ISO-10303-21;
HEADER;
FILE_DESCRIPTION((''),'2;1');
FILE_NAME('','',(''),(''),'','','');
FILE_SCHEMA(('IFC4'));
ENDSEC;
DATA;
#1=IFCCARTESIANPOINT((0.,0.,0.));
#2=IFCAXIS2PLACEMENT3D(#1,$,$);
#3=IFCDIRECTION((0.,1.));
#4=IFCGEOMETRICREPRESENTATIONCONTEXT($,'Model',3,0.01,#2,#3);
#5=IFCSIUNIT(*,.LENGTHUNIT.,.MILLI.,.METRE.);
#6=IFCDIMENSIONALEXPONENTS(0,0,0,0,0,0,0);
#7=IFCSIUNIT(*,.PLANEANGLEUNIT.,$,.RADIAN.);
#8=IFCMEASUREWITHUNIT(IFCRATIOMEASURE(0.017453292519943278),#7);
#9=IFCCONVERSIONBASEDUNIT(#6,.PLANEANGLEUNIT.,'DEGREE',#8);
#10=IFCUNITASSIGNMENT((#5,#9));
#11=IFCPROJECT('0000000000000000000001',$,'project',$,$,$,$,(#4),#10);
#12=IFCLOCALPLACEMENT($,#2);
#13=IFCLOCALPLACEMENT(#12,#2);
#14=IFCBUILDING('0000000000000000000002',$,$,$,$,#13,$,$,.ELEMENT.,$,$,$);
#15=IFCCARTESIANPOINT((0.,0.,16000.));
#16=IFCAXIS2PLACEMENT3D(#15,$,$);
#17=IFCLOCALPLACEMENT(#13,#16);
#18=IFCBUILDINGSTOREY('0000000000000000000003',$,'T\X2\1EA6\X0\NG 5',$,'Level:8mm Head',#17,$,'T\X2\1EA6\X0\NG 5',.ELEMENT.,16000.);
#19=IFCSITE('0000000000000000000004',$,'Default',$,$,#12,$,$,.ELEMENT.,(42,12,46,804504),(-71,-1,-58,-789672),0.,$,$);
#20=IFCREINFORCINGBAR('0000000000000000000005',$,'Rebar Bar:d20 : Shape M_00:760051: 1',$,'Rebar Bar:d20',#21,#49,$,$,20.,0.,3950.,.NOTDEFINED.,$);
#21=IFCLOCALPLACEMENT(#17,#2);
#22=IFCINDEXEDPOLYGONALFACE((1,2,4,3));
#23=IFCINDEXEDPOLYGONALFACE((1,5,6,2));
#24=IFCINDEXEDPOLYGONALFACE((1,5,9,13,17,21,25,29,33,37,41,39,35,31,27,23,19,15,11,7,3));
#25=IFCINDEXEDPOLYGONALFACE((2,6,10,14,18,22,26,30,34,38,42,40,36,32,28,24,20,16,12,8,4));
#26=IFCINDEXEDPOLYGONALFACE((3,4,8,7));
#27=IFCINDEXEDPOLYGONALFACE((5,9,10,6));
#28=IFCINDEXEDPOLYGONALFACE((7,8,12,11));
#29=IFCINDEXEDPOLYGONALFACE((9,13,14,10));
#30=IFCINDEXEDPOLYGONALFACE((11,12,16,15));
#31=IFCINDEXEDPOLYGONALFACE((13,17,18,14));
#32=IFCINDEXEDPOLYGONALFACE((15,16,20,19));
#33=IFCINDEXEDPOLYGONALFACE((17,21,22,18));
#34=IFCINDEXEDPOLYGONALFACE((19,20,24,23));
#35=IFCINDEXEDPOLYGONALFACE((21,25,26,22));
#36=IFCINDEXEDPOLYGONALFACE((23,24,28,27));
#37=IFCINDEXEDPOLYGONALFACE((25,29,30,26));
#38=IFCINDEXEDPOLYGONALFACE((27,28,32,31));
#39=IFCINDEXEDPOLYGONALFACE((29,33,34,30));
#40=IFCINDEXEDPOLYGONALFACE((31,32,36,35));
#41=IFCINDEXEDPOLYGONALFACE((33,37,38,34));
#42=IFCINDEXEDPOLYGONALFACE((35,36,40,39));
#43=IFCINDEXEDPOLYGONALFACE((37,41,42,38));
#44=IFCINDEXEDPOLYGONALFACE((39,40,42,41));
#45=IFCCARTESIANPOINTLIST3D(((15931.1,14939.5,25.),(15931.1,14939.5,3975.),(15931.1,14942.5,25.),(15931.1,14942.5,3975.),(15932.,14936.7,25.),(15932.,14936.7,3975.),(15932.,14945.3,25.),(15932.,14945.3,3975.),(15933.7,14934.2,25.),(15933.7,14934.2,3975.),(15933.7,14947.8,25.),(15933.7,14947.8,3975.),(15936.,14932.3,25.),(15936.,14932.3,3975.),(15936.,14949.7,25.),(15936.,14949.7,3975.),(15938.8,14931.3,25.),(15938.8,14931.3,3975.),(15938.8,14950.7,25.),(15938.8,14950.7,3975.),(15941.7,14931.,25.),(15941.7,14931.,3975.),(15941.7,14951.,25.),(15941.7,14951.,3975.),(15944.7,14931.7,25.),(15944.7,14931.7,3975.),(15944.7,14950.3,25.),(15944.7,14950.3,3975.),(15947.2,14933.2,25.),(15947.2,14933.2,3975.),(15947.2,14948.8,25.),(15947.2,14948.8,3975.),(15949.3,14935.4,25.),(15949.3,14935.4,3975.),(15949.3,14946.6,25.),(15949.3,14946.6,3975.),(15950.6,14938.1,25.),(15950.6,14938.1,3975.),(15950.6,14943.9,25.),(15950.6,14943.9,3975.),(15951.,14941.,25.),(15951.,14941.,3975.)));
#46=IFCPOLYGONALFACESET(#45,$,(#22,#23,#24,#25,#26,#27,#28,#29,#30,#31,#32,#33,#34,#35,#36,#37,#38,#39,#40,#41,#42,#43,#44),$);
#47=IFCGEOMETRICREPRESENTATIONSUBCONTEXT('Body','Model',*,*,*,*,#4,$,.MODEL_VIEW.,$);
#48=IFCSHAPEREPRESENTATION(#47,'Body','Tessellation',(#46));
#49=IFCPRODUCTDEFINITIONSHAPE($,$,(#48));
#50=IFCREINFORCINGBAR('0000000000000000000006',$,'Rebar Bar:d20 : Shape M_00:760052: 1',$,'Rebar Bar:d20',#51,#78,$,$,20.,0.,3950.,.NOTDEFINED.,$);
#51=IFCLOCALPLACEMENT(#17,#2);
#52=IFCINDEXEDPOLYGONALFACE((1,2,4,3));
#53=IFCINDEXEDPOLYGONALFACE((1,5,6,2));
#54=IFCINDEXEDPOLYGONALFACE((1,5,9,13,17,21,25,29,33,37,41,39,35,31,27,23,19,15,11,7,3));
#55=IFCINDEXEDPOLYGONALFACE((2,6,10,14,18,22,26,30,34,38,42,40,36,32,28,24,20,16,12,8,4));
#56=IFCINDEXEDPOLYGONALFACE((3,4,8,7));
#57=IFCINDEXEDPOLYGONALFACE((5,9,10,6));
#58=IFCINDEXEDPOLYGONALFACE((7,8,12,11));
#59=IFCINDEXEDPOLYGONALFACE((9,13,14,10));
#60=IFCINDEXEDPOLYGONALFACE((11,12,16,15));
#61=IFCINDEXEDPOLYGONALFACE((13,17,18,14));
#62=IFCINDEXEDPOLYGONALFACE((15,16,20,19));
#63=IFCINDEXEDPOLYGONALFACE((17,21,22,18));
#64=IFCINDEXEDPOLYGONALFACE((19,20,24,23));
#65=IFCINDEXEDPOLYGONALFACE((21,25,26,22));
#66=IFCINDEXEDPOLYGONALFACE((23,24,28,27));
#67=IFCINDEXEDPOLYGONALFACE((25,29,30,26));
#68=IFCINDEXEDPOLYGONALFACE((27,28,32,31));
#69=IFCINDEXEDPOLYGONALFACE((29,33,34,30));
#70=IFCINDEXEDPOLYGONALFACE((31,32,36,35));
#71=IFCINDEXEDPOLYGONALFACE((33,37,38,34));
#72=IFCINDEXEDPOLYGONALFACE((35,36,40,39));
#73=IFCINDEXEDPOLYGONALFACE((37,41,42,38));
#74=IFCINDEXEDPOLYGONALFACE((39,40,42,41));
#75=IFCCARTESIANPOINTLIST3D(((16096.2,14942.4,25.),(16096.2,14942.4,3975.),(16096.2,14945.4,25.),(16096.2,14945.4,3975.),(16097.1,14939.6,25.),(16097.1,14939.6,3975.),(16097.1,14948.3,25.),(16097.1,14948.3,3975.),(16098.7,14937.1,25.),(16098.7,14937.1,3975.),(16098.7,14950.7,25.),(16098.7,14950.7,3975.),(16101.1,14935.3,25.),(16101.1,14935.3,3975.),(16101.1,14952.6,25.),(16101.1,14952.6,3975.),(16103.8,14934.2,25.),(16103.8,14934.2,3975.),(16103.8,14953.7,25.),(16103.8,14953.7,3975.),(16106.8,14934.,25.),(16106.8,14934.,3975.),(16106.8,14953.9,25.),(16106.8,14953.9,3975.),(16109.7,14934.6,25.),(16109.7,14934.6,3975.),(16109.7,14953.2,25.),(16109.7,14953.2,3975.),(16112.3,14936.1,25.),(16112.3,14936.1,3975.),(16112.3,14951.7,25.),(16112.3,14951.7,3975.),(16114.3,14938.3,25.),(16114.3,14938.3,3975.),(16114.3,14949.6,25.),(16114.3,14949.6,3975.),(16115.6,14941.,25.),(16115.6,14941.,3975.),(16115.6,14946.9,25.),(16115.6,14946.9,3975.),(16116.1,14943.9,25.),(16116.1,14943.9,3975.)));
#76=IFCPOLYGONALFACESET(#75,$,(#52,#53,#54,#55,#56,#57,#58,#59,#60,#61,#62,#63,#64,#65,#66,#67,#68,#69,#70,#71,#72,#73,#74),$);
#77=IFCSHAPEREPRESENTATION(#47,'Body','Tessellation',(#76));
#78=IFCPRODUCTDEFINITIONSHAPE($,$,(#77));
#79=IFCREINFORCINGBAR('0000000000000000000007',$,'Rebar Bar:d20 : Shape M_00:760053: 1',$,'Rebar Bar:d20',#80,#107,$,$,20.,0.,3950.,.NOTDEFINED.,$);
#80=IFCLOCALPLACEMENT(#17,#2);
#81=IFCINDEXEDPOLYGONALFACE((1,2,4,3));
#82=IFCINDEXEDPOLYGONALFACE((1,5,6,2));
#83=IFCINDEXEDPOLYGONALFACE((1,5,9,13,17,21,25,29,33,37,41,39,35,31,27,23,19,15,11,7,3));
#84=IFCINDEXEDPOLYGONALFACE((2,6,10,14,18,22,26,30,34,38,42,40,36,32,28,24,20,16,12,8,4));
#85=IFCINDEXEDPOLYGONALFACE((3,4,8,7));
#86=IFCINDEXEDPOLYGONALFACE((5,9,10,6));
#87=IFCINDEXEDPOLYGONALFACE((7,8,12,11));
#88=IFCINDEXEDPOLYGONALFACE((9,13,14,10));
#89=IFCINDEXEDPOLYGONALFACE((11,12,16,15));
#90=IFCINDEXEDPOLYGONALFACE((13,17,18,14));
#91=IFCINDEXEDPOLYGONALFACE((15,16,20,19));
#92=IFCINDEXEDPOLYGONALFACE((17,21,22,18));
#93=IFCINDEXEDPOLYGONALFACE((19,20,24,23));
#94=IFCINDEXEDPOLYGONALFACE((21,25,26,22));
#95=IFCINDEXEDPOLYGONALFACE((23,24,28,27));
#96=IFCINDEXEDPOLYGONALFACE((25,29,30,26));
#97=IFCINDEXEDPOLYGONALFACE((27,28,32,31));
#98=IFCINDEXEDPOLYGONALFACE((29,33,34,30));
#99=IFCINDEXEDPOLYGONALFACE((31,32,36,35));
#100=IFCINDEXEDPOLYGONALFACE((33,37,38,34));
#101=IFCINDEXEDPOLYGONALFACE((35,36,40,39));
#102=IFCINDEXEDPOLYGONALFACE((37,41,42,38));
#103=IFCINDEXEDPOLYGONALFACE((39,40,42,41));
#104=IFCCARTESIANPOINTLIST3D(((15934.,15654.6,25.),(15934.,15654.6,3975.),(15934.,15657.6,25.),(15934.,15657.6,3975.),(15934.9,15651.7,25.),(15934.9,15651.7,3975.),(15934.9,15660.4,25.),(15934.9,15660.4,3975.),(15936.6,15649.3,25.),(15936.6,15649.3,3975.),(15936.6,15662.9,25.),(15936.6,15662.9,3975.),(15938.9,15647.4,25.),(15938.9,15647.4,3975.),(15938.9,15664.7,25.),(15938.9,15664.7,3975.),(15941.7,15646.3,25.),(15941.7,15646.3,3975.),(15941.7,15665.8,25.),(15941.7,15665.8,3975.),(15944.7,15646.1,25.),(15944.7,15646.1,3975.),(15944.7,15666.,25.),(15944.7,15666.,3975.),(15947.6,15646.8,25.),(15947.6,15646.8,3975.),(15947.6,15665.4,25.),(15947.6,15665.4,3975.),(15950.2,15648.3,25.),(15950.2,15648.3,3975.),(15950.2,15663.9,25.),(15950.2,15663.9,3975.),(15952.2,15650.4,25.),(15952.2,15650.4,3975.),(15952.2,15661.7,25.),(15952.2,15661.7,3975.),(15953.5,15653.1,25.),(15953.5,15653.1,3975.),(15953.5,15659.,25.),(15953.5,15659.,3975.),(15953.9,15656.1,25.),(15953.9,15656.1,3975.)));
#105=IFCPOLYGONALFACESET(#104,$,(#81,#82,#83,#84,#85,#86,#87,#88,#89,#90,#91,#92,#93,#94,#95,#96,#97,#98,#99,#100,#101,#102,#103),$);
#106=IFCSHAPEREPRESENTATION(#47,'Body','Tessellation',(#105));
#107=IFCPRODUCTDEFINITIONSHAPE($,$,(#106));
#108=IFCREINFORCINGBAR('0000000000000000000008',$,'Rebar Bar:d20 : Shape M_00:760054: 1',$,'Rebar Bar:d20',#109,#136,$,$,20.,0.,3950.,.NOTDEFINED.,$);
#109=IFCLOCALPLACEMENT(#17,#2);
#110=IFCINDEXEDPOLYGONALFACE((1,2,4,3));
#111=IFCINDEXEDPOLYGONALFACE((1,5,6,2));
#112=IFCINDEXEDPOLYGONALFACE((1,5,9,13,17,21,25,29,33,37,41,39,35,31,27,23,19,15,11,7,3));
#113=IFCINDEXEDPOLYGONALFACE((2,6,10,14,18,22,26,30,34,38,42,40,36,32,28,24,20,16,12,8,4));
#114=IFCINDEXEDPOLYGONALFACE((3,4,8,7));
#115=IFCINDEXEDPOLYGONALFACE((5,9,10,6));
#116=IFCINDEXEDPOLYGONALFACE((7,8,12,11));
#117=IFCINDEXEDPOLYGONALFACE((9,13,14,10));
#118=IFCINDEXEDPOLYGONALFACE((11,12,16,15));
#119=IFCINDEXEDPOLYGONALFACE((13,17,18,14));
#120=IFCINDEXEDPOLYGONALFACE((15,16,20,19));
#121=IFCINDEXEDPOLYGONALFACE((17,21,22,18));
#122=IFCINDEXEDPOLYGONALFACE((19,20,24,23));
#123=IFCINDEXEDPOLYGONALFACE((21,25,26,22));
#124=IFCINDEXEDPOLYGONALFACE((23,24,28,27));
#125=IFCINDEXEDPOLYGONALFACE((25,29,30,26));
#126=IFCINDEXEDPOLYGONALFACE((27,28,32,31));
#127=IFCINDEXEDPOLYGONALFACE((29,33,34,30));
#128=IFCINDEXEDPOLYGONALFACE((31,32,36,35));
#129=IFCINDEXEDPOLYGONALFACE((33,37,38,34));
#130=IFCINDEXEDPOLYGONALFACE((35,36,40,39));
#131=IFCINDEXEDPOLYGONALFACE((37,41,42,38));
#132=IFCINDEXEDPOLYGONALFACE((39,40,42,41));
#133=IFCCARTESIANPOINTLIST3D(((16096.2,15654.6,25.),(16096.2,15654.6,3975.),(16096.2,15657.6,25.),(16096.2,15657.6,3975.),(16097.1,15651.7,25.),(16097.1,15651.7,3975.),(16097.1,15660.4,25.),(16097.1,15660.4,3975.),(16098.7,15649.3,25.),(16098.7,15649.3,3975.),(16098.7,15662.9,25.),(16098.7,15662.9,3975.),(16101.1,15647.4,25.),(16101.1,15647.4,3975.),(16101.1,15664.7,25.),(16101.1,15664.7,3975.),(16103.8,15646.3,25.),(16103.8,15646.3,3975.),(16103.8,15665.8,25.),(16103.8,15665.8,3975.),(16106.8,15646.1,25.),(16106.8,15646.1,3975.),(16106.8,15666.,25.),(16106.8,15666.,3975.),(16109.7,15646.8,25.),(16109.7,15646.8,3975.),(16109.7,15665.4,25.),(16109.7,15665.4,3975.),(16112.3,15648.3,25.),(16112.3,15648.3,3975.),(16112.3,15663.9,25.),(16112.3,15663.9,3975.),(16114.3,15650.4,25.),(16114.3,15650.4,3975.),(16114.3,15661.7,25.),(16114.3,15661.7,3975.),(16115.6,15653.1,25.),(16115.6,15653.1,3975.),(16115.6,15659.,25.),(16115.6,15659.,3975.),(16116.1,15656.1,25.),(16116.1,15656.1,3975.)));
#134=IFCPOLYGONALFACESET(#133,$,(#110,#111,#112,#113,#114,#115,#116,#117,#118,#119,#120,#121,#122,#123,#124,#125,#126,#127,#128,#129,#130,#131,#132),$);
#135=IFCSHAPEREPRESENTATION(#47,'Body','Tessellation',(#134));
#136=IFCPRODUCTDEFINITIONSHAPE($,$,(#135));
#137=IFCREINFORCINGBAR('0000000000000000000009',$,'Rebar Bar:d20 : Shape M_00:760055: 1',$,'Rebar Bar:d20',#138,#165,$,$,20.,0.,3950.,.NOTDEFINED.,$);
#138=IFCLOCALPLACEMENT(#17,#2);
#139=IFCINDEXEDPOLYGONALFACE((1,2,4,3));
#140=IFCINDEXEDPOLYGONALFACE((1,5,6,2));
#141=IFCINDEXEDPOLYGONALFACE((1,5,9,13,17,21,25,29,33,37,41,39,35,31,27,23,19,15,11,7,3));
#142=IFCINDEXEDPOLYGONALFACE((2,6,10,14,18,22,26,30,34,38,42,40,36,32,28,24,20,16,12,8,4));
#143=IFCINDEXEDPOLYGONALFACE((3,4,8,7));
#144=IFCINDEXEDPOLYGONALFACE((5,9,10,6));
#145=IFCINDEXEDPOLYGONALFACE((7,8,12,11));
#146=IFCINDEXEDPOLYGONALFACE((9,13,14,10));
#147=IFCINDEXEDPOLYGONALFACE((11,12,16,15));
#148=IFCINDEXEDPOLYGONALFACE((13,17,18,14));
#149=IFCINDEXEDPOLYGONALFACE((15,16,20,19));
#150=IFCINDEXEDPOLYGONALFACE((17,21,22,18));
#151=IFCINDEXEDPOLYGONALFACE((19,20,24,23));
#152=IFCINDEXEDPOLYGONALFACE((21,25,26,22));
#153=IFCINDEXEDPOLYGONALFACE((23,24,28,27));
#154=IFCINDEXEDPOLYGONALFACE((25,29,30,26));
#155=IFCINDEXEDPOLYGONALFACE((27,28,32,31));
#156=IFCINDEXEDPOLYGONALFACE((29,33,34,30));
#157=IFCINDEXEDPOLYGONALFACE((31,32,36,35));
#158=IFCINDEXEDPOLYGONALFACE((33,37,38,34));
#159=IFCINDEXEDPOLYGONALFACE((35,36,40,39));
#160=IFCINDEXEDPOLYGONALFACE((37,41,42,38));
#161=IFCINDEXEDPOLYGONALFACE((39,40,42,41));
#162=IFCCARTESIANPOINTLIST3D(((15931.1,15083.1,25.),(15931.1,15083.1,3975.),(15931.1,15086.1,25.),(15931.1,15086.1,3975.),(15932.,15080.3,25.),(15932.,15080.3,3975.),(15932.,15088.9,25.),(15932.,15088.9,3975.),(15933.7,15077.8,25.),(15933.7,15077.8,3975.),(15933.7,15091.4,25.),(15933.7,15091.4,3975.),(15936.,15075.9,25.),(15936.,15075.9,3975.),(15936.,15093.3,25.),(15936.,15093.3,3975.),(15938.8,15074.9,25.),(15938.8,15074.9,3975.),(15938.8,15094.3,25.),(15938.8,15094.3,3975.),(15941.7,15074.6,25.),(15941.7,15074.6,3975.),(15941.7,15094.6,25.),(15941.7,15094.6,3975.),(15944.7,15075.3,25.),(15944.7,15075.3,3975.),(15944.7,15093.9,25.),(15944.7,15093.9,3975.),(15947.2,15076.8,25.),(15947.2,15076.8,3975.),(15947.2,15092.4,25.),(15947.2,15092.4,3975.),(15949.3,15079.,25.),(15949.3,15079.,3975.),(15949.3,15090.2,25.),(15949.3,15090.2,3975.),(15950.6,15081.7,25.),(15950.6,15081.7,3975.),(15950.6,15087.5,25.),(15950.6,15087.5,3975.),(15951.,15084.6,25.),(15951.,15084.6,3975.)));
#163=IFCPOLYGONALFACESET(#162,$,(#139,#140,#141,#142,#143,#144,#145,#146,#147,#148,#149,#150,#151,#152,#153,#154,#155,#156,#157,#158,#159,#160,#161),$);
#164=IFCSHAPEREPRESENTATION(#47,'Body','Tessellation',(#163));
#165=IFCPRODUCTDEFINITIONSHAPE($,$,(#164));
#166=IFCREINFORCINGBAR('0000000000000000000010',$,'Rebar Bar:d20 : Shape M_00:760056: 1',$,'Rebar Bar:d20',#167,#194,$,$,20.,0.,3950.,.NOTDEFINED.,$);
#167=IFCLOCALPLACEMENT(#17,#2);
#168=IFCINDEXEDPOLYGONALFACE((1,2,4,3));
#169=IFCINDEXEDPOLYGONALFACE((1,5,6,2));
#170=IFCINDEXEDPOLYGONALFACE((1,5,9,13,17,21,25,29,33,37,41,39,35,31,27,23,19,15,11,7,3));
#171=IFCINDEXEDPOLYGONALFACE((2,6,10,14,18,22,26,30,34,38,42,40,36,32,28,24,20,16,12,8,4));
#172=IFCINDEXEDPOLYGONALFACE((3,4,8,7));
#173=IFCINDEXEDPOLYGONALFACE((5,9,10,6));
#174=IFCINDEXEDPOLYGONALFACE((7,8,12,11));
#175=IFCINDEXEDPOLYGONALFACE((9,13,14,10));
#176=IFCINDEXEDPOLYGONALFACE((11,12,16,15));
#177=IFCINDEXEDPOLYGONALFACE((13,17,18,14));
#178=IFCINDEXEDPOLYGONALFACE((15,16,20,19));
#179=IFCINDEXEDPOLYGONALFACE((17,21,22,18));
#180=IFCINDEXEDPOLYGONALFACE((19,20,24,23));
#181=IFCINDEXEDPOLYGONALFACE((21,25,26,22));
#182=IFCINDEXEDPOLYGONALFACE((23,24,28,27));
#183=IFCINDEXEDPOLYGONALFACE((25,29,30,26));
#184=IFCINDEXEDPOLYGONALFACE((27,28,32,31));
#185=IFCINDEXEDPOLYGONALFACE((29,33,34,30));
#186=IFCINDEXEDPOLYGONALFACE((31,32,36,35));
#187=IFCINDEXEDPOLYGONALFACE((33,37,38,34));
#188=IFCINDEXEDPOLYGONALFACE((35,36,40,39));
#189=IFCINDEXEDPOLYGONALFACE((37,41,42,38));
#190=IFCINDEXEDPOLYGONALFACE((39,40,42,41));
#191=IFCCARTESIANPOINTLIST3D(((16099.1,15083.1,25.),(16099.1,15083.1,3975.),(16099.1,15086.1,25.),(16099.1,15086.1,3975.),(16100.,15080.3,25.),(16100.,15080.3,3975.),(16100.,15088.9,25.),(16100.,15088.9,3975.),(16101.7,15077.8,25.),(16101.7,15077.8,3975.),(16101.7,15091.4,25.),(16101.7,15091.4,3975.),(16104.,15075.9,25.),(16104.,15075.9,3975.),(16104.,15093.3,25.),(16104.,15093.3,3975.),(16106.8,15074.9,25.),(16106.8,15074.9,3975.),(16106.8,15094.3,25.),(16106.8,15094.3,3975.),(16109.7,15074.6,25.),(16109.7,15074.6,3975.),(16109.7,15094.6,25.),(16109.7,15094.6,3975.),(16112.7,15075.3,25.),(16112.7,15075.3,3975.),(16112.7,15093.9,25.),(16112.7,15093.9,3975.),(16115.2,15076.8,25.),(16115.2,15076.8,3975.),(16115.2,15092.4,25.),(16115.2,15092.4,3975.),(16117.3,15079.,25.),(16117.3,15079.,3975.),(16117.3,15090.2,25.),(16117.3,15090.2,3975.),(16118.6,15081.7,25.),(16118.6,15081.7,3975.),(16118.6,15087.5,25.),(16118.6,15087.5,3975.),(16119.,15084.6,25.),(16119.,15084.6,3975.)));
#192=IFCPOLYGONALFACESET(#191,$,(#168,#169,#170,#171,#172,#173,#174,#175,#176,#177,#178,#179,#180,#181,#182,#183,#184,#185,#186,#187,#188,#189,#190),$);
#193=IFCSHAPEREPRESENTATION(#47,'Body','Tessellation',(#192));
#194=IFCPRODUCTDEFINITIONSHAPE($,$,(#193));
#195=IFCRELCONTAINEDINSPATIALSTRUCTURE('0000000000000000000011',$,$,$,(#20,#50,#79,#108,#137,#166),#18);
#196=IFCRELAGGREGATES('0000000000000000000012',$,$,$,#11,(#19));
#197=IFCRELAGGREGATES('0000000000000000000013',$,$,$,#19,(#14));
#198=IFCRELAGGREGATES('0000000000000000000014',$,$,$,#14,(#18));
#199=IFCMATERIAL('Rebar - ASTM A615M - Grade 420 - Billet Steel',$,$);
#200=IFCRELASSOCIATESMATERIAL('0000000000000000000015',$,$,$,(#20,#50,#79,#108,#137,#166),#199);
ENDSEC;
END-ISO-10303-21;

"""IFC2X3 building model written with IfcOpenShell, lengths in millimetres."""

from ifc_helpers import new_model, entity, si_unit, converted_unit, direction, frame, origin, place, context, subcontext, project, spatial, material, element, save


model = new_model("IFC2X3")

# Units and contexts
model_context = context("Model", 3, precision=0.01, world=origin(), true_north=direction((0.0, 1.0)))
body_context = subcontext(model_context, "Body", "Model", "MODEL_VIEW")
ifc_project = project(units=[si_unit("LENGTHUNIT", "METRE", prefix="MILLI"), converted_unit("PLANEANGLEUNIT", "DEGREE", entity("IfcRatioMeasure", 0.017453292519943278), si_unit("PLANEANGLEUNIT", "RADIAN"), dimensions=[0, 0, 0, 0, 0, 0, 0])], contexts=[model_context])

# Site, building, storey
site_placement = place(None, origin())
site = spatial("IfcSite", under=ifc_project, at=site_placement, Name="Default", CompositionType="ELEMENT", RefLatitude=(42, 12, 46, 804504), RefLongitude=(-71, -1, -58, -789672), RefElevation=0.0)
building_placement = place(site_placement, origin())
building = spatial("IfcBuilding", under=site, at=building_placement, CompositionType="ELEMENT")
storey_placement = place(building_placement, frame((0.0, 0.0, 16000.0)))
storey = spatial("IfcBuildingStorey", under=building, at=storey_placement, Name="TẦNG 5", ObjectType="Level:8mm Head", LongName="TẦNG 5", CompositionType="ELEMENT", Elevation=16000.0)

# Reinforcing bars
ifc_material = material(Name="Rebar - ASTM A615M - Grade 420 - Billet Steel")
reinforcing_bar_1_placement = place(storey_placement, origin())
element("IfcReinforcingBar", 1, at=reinforcing_bar_1_placement, inside=storey, material=ifc_material, Name="Rebar Bar:d20 : Shape M_00:760051: 1", ObjectType="Rebar Bar:d20", BarLength=3950.0, BarRole="NOTDEFINED", CrossSectionArea=0.0, NominalDiameter=20.0, context=body_context, shape_type="AdvancedSweptSolid", body=[
    entity("IfcSweptDiskSolid", entity("IfcCompositeCurve", [entity("IfcCompositeCurveSegment", "CONTINUOUS", True, entity("IfcPolyline", [entity("IfcCartesianPoint", [15941.0, 14941.0, 25.0]), entity("IfcCartesianPoint", [15941.0, 14941.0, 3975.0])]))], False), 10.0, None, 0.0, 1.0),
])
reinforcing_bar_2_placement = place(storey_placement, origin())
element("IfcReinforcingBar", 2, at=reinforcing_bar_2_placement, inside=storey, material=ifc_material, Name="Rebar Bar:d20 : Shape M_00:760052: 1", ObjectType="Rebar Bar:d20", BarLength=3950.0, BarRole="NOTDEFINED", CrossSectionArea=0.0, NominalDiameter=20.0, context=body_context, shape_type="AdvancedSweptSolid", body=[
    entity("IfcSweptDiskSolid", entity("IfcCompositeCurve", [entity("IfcCompositeCurveSegment", "CONTINUOUS", True, entity("IfcPolyline", [entity("IfcCartesianPoint", [16106.1, 14943.9, 25.0]), entity("IfcCartesianPoint", [16106.1, 14943.9, 3975.0])]))], False), 10.0, None, 0.0, 1.0),
])
reinforcing_bar_3_placement = place(storey_placement, origin())
element("IfcReinforcingBar", 3, at=reinforcing_bar_3_placement, inside=storey, material=ifc_material, Name="Rebar Bar:d20 : Shape M_00:760053: 1", ObjectType="Rebar Bar:d20", BarLength=3950.0, BarRole="NOTDEFINED", CrossSectionArea=0.0, NominalDiameter=20.0, context=body_context, shape_type="AdvancedSweptSolid", body=[
    entity("IfcSweptDiskSolid", entity("IfcCompositeCurve", [entity("IfcCompositeCurveSegment", "CONTINUOUS", True, entity("IfcPolyline", [entity("IfcCartesianPoint", [15943.9, 15656.1, 25.0]), entity("IfcCartesianPoint", [15943.9, 15656.1, 3975.0])]))], False), 10.0, None, 0.0, 1.0),
])
reinforcing_bar_4_placement = place(storey_placement, origin())
element("IfcReinforcingBar", 4, at=reinforcing_bar_4_placement, inside=storey, material=ifc_material, Name="Rebar Bar:d20 : Shape M_00:760054: 1", ObjectType="Rebar Bar:d20", BarLength=3950.0, BarRole="NOTDEFINED", CrossSectionArea=0.0, NominalDiameter=20.0, context=body_context, shape_type="AdvancedSweptSolid", body=[
    entity("IfcSweptDiskSolid", entity("IfcCompositeCurve", [entity("IfcCompositeCurveSegment", "CONTINUOUS", True, entity("IfcPolyline", [entity("IfcCartesianPoint", [16106.1, 15656.1, 25.0]), entity("IfcCartesianPoint", [16106.1, 15656.1, 3975.0])]))], False), 10.0, None, 0.0, 1.0),
])
reinforcing_bar_5_placement = place(storey_placement, origin())
element("IfcReinforcingBar", 5, at=reinforcing_bar_5_placement, inside=storey, material=ifc_material, Name="Rebar Bar:d20 : Shape M_00:760055: 1", ObjectType="Rebar Bar:d20", BarLength=3950.0, BarRole="NOTDEFINED", CrossSectionArea=0.0, NominalDiameter=20.0, context=body_context, shape_type="AdvancedSweptSolid", body=[
    entity("IfcSweptDiskSolid", entity("IfcCompositeCurve", [entity("IfcCompositeCurveSegment", "CONTINUOUS", True, entity("IfcPolyline", [entity("IfcCartesianPoint", [15941.0, 15084.6, 25.0]), entity("IfcCartesianPoint", [15941.0, 15084.6, 3975.0])]))], False), 10.0, None, 0.0, 1.0),
])
reinforcing_bar_6_placement = place(storey_placement, origin())
element("IfcReinforcingBar", 6, at=reinforcing_bar_6_placement, inside=storey, material=ifc_material, Name="Rebar Bar:d20 : Shape M_00:760056: 1", ObjectType="Rebar Bar:d20", BarLength=3950.0, BarRole="NOTDEFINED", CrossSectionArea=0.0, NominalDiameter=20.0, context=body_context, shape_type="AdvancedSweptSolid", body=[
    entity("IfcSweptDiskSolid", entity("IfcCompositeCurve", [entity("IfcCompositeCurveSegment", "CONTINUOUS", True, entity("IfcPolyline", [entity("IfcCartesianPoint", [16109.0, 15084.6, 25.0]), entity("IfcCartesianPoint", [16109.0, 15084.6, 3975.0])]))], False), 10.0, None, 0.0, 1.0),
])

save(model, "model.ifc")
